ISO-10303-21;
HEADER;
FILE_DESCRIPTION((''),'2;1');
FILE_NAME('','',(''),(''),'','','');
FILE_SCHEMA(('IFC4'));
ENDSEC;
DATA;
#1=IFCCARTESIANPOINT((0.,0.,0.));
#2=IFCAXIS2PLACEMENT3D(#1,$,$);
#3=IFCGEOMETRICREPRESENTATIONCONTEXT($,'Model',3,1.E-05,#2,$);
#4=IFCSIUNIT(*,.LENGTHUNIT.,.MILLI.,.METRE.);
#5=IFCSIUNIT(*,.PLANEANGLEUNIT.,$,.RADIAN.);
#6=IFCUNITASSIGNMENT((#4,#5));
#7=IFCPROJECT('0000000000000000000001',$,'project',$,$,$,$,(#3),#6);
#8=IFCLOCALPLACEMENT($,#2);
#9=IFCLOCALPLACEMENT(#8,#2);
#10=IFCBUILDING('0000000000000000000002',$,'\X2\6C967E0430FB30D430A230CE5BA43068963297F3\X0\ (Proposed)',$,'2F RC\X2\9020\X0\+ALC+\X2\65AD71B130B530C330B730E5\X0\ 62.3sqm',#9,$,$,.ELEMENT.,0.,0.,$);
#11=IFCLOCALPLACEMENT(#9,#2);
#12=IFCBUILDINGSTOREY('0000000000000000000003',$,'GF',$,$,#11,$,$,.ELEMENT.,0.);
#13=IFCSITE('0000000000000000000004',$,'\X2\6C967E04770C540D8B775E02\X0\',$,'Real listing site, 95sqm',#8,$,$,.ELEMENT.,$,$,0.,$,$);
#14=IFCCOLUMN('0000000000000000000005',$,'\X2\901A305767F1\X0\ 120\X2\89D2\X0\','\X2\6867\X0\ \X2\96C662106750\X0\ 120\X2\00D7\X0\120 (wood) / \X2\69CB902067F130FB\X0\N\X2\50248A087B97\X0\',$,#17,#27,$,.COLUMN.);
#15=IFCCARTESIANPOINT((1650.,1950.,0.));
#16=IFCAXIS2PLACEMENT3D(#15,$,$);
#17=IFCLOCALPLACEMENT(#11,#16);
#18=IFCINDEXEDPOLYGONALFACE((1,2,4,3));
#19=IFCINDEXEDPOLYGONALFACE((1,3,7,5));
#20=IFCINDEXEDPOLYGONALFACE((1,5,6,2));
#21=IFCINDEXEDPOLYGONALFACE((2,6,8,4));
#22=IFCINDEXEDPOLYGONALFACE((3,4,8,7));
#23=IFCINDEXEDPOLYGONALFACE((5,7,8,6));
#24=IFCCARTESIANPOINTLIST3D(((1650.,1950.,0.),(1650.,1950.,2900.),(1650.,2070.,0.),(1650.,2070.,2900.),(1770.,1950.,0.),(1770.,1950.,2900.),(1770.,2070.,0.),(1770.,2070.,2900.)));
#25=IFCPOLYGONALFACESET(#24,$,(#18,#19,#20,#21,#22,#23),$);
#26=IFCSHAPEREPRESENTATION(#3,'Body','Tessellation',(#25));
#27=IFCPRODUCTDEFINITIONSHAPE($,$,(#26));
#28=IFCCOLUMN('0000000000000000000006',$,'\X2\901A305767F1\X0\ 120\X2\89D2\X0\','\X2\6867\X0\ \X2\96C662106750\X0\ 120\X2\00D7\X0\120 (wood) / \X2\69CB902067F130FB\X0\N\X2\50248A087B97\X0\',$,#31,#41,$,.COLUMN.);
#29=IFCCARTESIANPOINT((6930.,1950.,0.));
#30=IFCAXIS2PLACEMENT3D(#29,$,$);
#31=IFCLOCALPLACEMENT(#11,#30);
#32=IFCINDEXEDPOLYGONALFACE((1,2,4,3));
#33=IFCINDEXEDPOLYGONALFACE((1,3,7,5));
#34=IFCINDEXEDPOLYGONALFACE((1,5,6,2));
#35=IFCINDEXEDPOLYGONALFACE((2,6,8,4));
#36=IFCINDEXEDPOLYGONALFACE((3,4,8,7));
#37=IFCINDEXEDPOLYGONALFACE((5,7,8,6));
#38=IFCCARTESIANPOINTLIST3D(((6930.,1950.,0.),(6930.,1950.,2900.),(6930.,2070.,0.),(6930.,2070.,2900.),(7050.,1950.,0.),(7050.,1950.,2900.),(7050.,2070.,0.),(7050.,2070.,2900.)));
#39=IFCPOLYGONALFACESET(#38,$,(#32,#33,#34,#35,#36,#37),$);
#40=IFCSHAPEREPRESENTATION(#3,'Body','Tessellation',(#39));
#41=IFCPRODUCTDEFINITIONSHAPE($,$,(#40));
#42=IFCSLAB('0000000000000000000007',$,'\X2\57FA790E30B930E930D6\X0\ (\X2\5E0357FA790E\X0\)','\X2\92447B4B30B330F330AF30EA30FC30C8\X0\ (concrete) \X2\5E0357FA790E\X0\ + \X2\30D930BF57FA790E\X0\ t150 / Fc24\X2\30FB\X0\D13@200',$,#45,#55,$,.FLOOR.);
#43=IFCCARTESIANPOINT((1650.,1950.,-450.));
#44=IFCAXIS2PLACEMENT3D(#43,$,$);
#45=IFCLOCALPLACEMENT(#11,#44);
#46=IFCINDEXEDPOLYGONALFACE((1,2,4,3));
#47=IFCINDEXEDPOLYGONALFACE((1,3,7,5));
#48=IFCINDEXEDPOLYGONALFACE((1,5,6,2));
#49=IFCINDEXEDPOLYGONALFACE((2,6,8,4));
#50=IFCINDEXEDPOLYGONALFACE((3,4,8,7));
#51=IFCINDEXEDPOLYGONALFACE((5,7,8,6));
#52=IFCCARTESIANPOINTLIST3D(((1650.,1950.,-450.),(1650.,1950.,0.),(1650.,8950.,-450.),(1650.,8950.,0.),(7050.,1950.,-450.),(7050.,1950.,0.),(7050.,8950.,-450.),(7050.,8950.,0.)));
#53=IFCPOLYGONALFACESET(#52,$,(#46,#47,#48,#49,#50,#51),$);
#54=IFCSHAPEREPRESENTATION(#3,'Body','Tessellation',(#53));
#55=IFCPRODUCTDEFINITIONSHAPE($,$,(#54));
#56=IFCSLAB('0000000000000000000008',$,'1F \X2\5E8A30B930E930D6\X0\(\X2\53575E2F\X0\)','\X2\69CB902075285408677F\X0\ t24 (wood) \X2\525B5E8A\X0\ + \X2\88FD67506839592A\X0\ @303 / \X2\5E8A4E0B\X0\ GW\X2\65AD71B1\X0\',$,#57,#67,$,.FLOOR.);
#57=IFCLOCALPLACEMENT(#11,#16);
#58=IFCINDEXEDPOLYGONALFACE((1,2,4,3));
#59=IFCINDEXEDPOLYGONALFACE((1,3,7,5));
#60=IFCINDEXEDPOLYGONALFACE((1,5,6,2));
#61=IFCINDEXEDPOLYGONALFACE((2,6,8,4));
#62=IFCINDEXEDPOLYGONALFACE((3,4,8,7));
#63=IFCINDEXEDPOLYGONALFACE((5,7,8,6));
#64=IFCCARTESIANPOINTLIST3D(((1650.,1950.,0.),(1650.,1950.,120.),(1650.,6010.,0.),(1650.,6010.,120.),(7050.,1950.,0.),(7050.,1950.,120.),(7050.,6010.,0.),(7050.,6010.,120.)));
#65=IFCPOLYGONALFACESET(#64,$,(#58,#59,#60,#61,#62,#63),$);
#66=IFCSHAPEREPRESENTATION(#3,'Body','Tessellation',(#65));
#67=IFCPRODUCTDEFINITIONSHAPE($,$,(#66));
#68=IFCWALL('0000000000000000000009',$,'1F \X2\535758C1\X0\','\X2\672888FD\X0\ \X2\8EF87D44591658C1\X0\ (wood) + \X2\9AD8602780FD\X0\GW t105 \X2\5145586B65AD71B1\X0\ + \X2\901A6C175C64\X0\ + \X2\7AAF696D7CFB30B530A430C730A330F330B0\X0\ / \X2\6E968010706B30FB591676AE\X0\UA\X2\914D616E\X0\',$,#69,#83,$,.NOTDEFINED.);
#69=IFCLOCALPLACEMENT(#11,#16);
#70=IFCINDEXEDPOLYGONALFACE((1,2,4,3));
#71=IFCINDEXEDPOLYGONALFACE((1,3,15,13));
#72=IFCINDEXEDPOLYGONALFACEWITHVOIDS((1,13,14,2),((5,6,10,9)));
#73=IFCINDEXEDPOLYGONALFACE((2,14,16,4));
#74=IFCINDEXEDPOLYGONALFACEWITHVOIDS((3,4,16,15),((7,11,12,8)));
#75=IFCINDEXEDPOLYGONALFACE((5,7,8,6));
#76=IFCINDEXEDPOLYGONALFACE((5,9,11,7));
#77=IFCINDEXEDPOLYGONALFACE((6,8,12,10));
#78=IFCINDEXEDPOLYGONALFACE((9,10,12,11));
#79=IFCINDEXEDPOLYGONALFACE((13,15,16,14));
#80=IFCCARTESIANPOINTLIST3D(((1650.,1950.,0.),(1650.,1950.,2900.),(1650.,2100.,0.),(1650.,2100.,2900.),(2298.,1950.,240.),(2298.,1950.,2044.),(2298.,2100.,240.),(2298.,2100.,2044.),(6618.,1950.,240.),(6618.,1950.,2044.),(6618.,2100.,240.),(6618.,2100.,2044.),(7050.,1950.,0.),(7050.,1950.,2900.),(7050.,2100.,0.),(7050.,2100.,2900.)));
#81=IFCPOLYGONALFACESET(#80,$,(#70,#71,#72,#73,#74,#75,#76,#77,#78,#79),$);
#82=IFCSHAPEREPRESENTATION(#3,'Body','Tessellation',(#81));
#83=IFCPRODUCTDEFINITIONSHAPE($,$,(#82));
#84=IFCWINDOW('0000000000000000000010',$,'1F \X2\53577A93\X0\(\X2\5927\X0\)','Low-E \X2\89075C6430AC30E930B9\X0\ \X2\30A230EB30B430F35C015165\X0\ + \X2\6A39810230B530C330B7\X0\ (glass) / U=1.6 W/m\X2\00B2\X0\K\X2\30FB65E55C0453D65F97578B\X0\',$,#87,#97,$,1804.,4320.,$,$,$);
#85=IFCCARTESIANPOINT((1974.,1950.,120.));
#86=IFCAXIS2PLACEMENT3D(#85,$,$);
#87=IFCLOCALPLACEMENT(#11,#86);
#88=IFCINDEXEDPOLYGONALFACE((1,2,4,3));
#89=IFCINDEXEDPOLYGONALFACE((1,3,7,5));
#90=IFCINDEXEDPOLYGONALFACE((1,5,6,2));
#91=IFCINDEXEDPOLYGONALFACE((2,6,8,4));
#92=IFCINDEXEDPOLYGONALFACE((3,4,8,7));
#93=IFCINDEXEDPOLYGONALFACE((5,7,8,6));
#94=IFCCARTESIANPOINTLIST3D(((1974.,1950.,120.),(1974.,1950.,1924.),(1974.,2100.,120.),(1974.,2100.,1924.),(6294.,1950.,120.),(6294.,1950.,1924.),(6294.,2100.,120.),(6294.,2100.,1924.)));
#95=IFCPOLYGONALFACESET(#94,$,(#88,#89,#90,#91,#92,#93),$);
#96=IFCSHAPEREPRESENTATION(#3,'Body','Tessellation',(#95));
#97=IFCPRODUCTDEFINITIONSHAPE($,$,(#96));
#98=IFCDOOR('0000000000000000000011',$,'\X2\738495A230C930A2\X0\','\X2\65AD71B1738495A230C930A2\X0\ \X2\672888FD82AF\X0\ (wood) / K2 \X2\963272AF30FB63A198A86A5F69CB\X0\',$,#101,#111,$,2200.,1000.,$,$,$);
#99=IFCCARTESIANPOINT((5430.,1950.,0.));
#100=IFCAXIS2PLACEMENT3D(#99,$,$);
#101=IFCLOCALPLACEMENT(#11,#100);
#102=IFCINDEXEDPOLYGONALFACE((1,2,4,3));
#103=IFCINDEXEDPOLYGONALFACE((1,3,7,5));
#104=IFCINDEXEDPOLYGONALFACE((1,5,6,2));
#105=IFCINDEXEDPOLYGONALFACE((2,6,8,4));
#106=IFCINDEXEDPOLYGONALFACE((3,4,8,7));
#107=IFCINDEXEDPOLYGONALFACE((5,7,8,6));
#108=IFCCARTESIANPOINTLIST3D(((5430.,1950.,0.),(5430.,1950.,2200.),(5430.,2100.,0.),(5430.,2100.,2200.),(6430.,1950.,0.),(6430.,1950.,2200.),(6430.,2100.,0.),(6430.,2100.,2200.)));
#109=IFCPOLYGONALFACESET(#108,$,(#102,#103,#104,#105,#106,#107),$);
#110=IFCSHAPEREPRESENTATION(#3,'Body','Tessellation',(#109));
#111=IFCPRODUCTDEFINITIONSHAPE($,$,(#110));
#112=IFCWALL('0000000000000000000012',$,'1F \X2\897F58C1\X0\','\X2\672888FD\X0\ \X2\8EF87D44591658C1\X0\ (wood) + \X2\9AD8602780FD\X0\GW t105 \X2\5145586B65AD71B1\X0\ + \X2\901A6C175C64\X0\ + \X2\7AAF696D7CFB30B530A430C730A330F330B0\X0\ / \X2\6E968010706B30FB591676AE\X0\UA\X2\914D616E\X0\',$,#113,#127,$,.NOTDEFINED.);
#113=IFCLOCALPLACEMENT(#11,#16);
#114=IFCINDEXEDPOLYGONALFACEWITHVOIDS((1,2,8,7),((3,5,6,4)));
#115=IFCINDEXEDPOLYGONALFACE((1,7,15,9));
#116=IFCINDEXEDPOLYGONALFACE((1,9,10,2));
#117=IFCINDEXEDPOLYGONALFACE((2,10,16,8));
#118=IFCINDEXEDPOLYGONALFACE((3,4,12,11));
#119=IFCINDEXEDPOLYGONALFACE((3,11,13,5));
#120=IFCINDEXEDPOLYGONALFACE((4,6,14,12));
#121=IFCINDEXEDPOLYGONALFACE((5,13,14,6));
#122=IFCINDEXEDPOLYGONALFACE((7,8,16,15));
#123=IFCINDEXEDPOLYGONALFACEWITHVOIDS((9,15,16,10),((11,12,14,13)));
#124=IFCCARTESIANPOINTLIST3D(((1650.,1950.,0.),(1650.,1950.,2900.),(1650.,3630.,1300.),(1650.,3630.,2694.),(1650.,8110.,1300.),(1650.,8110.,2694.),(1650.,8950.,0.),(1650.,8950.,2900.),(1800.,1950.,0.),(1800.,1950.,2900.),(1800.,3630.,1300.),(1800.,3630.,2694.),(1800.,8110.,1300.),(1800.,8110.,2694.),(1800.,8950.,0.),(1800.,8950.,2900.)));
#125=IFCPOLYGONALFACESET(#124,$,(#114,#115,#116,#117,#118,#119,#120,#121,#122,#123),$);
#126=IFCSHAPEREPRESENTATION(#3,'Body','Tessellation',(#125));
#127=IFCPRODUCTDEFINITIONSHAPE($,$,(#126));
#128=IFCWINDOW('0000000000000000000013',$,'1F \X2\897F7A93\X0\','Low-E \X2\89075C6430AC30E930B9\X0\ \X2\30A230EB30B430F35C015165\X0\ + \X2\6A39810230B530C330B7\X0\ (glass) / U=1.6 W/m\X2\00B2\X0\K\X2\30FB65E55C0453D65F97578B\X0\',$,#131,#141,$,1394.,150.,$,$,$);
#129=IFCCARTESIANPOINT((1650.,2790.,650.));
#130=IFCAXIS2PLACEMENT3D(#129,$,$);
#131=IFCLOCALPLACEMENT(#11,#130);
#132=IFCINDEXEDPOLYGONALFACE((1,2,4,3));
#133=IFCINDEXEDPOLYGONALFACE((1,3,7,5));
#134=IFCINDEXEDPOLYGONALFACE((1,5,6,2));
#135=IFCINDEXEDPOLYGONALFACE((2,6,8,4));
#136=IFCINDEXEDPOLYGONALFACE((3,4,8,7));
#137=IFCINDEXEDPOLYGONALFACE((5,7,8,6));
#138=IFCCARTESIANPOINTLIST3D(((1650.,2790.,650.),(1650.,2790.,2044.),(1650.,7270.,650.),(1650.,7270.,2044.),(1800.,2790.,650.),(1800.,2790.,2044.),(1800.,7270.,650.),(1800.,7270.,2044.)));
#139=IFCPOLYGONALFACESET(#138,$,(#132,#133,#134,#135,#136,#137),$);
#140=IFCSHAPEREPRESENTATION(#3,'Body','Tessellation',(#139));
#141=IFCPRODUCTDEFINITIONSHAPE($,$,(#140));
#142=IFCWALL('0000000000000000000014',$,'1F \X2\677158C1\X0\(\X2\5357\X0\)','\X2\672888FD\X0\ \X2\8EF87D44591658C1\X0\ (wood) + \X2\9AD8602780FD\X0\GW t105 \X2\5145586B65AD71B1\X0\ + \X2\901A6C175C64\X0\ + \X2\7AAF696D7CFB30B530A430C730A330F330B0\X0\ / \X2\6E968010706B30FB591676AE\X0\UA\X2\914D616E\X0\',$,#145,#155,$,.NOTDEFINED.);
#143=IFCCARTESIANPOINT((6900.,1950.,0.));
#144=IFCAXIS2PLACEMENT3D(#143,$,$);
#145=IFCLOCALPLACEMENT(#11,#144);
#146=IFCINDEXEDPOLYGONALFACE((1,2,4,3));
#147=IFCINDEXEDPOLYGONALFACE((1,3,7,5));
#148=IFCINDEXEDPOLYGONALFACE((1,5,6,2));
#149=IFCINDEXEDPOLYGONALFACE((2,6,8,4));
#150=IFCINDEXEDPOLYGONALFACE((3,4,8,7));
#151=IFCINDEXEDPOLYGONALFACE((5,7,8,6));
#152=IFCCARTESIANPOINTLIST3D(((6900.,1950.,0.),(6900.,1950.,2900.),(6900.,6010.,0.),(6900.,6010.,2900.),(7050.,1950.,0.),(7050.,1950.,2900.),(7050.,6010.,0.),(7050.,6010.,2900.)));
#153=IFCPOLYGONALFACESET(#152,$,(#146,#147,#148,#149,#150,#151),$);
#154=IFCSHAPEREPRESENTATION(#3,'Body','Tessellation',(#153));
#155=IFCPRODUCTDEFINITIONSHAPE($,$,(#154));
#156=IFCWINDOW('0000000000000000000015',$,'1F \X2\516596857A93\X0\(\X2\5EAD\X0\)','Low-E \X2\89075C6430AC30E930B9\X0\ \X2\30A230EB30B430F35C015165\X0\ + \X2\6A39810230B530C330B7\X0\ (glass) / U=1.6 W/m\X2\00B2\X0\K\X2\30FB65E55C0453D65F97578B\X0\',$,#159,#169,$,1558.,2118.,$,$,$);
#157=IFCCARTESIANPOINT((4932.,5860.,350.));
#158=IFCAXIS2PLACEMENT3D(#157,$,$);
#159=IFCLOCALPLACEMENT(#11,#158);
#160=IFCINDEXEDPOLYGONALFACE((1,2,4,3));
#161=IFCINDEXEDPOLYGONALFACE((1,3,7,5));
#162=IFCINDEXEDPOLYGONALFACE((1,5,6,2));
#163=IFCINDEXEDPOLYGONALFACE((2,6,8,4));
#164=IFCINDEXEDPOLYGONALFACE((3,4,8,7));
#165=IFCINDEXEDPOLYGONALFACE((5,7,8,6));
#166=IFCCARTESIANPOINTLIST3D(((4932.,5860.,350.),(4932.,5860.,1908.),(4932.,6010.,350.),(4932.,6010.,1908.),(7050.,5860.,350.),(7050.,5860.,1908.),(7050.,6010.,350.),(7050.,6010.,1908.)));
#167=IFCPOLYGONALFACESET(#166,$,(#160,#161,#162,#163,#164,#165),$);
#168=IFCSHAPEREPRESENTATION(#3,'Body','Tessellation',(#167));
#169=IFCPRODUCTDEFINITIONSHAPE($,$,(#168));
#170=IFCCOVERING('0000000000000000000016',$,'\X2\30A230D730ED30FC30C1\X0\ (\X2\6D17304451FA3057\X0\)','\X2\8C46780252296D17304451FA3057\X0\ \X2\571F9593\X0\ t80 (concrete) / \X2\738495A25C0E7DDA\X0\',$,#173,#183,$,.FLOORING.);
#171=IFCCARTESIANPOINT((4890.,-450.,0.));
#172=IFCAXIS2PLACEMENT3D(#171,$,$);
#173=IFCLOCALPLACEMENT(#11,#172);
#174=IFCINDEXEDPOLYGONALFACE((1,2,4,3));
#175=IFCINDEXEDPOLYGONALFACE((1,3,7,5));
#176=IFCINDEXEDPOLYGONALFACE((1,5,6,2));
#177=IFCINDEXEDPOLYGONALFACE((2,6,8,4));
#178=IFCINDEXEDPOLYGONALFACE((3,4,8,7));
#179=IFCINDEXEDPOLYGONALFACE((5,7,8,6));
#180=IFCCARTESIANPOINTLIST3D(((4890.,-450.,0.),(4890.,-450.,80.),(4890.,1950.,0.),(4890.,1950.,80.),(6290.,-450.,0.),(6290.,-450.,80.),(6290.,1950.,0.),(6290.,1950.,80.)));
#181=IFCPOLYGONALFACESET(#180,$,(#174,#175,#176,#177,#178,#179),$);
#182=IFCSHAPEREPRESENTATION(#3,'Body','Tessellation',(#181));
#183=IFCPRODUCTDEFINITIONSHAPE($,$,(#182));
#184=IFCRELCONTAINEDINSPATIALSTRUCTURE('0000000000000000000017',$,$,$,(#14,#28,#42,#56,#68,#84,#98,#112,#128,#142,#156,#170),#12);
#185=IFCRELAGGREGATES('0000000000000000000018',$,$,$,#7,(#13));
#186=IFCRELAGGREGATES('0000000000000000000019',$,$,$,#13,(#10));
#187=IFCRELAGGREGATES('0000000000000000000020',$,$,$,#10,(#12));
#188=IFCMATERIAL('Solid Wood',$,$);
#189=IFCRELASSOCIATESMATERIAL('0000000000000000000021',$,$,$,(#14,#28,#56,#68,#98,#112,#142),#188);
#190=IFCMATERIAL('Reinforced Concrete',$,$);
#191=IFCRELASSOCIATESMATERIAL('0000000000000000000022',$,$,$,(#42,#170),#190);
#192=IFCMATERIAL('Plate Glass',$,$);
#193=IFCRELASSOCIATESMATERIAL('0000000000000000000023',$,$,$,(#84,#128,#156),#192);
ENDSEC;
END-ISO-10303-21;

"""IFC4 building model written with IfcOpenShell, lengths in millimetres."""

from ifc_helpers import new_model, si_unit, frame, frame_2d, origin, place, context, project, spatial, rectangle, extrude, material, element, fill, save


model = new_model("IFC4")

# Units and contexts
model_context = context("Model", 3, precision=1e-05, world=origin())
ifc_project = project(units=[si_unit("LENGTHUNIT", "METRE", prefix="MILLI"), si_unit("PLANEANGLEUNIT", "RADIAN")], contexts=[model_context])

# Site, building, storey
site_placement = place(None, origin())
site = spatial("IfcSite", under=ifc_project, at=site_placement, Name="沖縄県名護市", ObjectType="Real listing site, 95sqm", CompositionType="ELEMENT", RefElevation=0.0)
building_placement = place(site_placement, origin())
building = spatial("IfcBuilding", under=site, at=building_placement, Name="沖縄・ピアノ室と防音 (Proposed)", ObjectType="2F RC造+ALC+断熱サッシュ 62.3sqm", CompositionType="ELEMENT", ElevationOfRefHeight=0.0, ElevationOfTerrain=0.0)
storey_placement = place(building_placement, origin())
storey = spatial("IfcBuildingStorey", under=building, at=storey_placement, Name="GF", CompositionType="ELEMENT", Elevation=0.0)

# Columns
ifc_material_1 = material(Name="Solid Wood")
column_1_placement = place(storey_placement, frame((1650.0, 1950.0, 0.0)))
element("IfcColumn", 1, at=column_1_placement, inside=storey, material=ifc_material_1, Name="通し柱 120角", Description="桧 集成材 120×120 (wood) / 構造柱・N値計算", PredefinedType="COLUMN", context=model_context, shape_type="SweptSolid", body=[
    extrude(rectangle(XDim=120.0, YDim=120.0, at=frame_2d((60.0, 60.0))), frame((1650.0, 1950.0, 0.0)), (0.0, 0.0, 1.0), 2900.0),
])
column_2_placement = place(storey_placement, frame((6930.0, 1950.0, 0.0)))
element("IfcColumn", 2, at=column_2_placement, inside=storey, material=ifc_material_1, Name="通し柱 120角", Description="桧 集成材 120×120 (wood) / 構造柱・N値計算", PredefinedType="COLUMN", context=model_context, shape_type="SweptSolid", body=[
    extrude(rectangle(XDim=120.0, YDim=120.0, at=frame_2d((60.0, 60.0))), frame((6930.0, 1950.0, 0.0)), (0.0, 0.0, 1.0), 2900.0),
])

# Slabs
ifc_material_2 = material(Name="Reinforced Concrete")
slab_1_placement = place(storey_placement, frame((1650.0, 1950.0, -450.0)))
element("IfcSlab", 3, at=slab_1_placement, inside=storey, material=ifc_material_2, Name="基礎スラブ (布基礎)", Description="鉄筋コンクリート (concrete) 布基礎 + ベタ基礎 t150 / Fc24・D13@200", PredefinedType="FLOOR", context=model_context, shape_type="SweptSolid", body=[
    extrude(rectangle(XDim=5400.0, YDim=7000.0, at=frame_2d((2700.0, 3500.0))), frame((1650.0, 1950.0, -450.0)), (0.0, 0.0, 1.0), 450.0),
])
slab_2_placement = place(storey_placement, frame((1650.0, 1950.0, 0.0)))
element("IfcSlab", 4, at=slab_2_placement, inside=storey, material=ifc_material_1, Name="1F 床スラブ(南帯)", Description="構造用合板 t24 (wood) 剛床 + 製材根太 @303 / 床下 GW断熱", PredefinedType="FLOOR", context=model_context, shape_type="SweptSolid", body=[
    extrude(rectangle(XDim=5400.0, YDim=4060.0, at=frame_2d((2700.0, 2030.0))), frame((1650.0, 1950.0, 0.0)), (0.0, 0.0, 1.0), 120.0),
])

# Wall, openings, window, door
wall_1_placement = place(storey_placement, frame((1650.0, 1950.0, 0.0)))
wall_1 = element("IfcWall", 5, at=wall_1_placement, inside=storey, material=ifc_material_1, Name="1F 南壁", Description="木製 軸組外壁 (wood) + 高性能GW t105 充填断熱 + 通気層 + 窯業系サイディング / 準耐火・外皮UA配慮", PredefinedType="NOTDEFINED", context=model_context, shape_type="SweptSolid", body=[
    extrude(rectangle(XDim=5400.0, YDim=150.0, at=frame_2d((2700.0, 75.0))), frame((1650.0, 1950.0, 0.0)), (0.0, 0.0, 1.0), 2900.0),
])
opening_1_placement = place(storey_placement, frame((1974.0, 1950.0, 120.0)))
opening_1 = element("IfcOpeningElement", 6, at=opening_1_placement, cuts=wall_1, PredefinedType="NOTDEFINED", context=model_context, shape_type="SweptSolid", body=[
    extrude(rectangle(XDim=4320.0, YDim=150.0, at=frame_2d((2160.0, 75.0))), frame((1974.0, 1950.0, 120.0)), (0.0, 0.0, 1.0), 1804.0),
])
opening_2_placement = place(storey_placement, frame((5430.0, 1950.0, 0.0)))
opening_2 = element("IfcOpeningElement", 7, at=opening_2_placement, cuts=wall_1, PredefinedType="NOTDEFINED", context=model_context, shape_type="SweptSolid", body=[
    extrude(rectangle(XDim=1000.0, YDim=150.0, at=frame_2d((500.0, 75.0))), frame((5430.0, 1950.0, 0.0)), (0.0, 0.0, 1.0), 2200.0),
])
ifc_material_3 = material(Name="Plate Glass")
window_1_placement = place(storey_placement, frame((1974.0, 1950.0, 120.0)))
window_1 = element("IfcWindow", 8, at=window_1_placement, inside=storey, material=ifc_material_3, Name="1F 南窓(大)", Description="Low-E 複層ガラス アルゴン封入 + 樹脂サッシ (glass) / U=1.6 W/m²K・日射取得型", OverallHeight=1804.0, OverallWidth=4320.0, context=model_context, shape_type="SweptSolid", body=[
    extrude(rectangle(XDim=4320.0, YDim=150.0, at=frame_2d((2160.0, 75.0))), frame((1974.0, 1950.0, 120.0)), (0.0, 0.0, 1.0), 1804.0),
])
fill(opening_1, window_1)
door_1_placement = place(storey_placement, frame((5430.0, 1950.0, 0.0)))
door_1 = element("IfcDoor", 9, at=door_1_placement, inside=storey, material=ifc_material_1, Name="玄関ドア", Description="断熱玄関ドア 木製芯 (wood) / K2 防犯・採風機構", OverallHeight=2200.0, OverallWidth=1000.0, context=model_context, shape_type="SweptSolid", body=[
    extrude(rectangle(XDim=1000.0, YDim=150.0, at=frame_2d((500.0, 75.0))), frame((5430.0, 1950.0, 0.0)), (0.0, 0.0, 1.0), 2200.0),
])
fill(opening_2, door_1)

# Walls, openings, windows
wall_2_placement = place(storey_placement, frame((1650.0, 1950.0, 0.0)))
wall_2 = element("IfcWall", 10, at=wall_2_placement, inside=storey, material=ifc_material_1, Name="1F 西壁", Description="木製 軸組外壁 (wood) + 高性能GW t105 充填断熱 + 通気層 + 窯業系サイディング / 準耐火・外皮UA配慮", PredefinedType="NOTDEFINED", context=model_context, shape_type="SweptSolid", body=[
    extrude(rectangle(XDim=150.0, YDim=7000.0, at=frame_2d((75.0, 3500.0))), frame((1650.0, 1950.0, 0.0)), (0.0, 0.0, 1.0), 2900.0),
])
opening_3_placement = place(storey_placement, frame((1650.0, 2790.0, 650.0)))
opening_3 = element("IfcOpeningElement", 11, at=opening_3_placement, cuts=wall_2, PredefinedType="NOTDEFINED", context=model_context, shape_type="SweptSolid", body=[
    extrude(rectangle(XDim=150.0, YDim=4480.0, at=frame_2d((75.0, 2240.0))), frame((1650.0, 2790.0, 650.0)), (0.0, 0.0, 1.0), 1394.0),
])
window_2_placement = place(storey_placement, frame((1650.0, 2790.0, 650.0)))
window_2 = element("IfcWindow", 12, at=window_2_placement, inside=storey, material=ifc_material_3, Name="1F 西窓", Description="Low-E 複層ガラス アルゴン封入 + 樹脂サッシ (glass) / U=1.6 W/m²K・日射取得型", OverallHeight=1394.0, OverallWidth=150.0, context=model_context, shape_type="SweptSolid", body=[
    extrude(rectangle(XDim=150.0, YDim=4480.0, at=frame_2d((75.0, 2240.0))), frame((1650.0, 2790.0, 650.0)), (0.0, 0.0, 1.0), 1394.0),
])
fill(opening_3, window_2)
wall_3_placement = place(storey_placement, frame((6900.0, 1950.0, 0.0)))
wall_3 = element("IfcWall", 13, at=wall_3_placement, inside=storey, material=ifc_material_1, Name="1F 東壁(南)", Description="木製 軸組外壁 (wood) + 高性能GW t105 充填断熱 + 通気層 + 窯業系サイディング / 準耐火・外皮UA配慮", PredefinedType="NOTDEFINED", context=model_context, shape_type="SweptSolid", body=[
    extrude(rectangle(XDim=150.0, YDim=4060.0, at=frame_2d((75.0, 2030.0))), frame((6900.0, 1950.0, 0.0)), (0.0, 0.0, 1.0), 2900.0),
])
opening_4_placement = place(storey_placement, frame((4932.0, 5860.0, 350.0)))
opening_4 = element("IfcOpeningElement", 14, at=opening_4_placement, cuts=wall_3, PredefinedType="NOTDEFINED", context=model_context, shape_type="SweptSolid", body=[
    extrude(rectangle(XDim=2118.0, YDim=150.0, at=frame_2d((1059.0, 75.0))), frame((4932.0, 5860.0, 350.0)), (0.0, 0.0, 1.0), 1558.0),
])
window_3_placement = place(storey_placement, frame((4932.0, 5860.0, 350.0)))
window_3 = element("IfcWindow", 15, at=window_3_placement, inside=storey, material=ifc_material_3, Name="1F 入隅窓(庭)", Description="Low-E 複層ガラス アルゴン封入 + 樹脂サッシ (glass) / U=1.6 W/m²K・日射取得型", OverallHeight=1558.0, OverallWidth=2118.0, context=model_context, shape_type="SweptSolid", body=[
    extrude(rectangle(XDim=2118.0, YDim=150.0, at=frame_2d((1059.0, 75.0))), frame((4932.0, 5860.0, 350.0)), (0.0, 0.0, 1.0), 1558.0),
])
fill(opening_4, window_3)

# Covering
covering_1_placement = place(storey_placement, frame((4890.0, -450.0, 0.0)))
element("IfcCovering", 16, at=covering_1_placement, inside=storey, material=ifc_material_2, Name="アプローチ (洗い出し)", Description="豆砂利洗い出し 土間 t80 (concrete) / 玄関導線", PredefinedType="FLOORING", context=model_context, shape_type="SweptSolid", body=[
    extrude(rectangle(XDim=1400.0, YDim=2400.0, at=frame_2d((700.0, 1200.0))), frame((4890.0, -450.0, 0.0)), (0.0, 0.0, 1.0), 80.0),
])

save(model, "model.ifc")
